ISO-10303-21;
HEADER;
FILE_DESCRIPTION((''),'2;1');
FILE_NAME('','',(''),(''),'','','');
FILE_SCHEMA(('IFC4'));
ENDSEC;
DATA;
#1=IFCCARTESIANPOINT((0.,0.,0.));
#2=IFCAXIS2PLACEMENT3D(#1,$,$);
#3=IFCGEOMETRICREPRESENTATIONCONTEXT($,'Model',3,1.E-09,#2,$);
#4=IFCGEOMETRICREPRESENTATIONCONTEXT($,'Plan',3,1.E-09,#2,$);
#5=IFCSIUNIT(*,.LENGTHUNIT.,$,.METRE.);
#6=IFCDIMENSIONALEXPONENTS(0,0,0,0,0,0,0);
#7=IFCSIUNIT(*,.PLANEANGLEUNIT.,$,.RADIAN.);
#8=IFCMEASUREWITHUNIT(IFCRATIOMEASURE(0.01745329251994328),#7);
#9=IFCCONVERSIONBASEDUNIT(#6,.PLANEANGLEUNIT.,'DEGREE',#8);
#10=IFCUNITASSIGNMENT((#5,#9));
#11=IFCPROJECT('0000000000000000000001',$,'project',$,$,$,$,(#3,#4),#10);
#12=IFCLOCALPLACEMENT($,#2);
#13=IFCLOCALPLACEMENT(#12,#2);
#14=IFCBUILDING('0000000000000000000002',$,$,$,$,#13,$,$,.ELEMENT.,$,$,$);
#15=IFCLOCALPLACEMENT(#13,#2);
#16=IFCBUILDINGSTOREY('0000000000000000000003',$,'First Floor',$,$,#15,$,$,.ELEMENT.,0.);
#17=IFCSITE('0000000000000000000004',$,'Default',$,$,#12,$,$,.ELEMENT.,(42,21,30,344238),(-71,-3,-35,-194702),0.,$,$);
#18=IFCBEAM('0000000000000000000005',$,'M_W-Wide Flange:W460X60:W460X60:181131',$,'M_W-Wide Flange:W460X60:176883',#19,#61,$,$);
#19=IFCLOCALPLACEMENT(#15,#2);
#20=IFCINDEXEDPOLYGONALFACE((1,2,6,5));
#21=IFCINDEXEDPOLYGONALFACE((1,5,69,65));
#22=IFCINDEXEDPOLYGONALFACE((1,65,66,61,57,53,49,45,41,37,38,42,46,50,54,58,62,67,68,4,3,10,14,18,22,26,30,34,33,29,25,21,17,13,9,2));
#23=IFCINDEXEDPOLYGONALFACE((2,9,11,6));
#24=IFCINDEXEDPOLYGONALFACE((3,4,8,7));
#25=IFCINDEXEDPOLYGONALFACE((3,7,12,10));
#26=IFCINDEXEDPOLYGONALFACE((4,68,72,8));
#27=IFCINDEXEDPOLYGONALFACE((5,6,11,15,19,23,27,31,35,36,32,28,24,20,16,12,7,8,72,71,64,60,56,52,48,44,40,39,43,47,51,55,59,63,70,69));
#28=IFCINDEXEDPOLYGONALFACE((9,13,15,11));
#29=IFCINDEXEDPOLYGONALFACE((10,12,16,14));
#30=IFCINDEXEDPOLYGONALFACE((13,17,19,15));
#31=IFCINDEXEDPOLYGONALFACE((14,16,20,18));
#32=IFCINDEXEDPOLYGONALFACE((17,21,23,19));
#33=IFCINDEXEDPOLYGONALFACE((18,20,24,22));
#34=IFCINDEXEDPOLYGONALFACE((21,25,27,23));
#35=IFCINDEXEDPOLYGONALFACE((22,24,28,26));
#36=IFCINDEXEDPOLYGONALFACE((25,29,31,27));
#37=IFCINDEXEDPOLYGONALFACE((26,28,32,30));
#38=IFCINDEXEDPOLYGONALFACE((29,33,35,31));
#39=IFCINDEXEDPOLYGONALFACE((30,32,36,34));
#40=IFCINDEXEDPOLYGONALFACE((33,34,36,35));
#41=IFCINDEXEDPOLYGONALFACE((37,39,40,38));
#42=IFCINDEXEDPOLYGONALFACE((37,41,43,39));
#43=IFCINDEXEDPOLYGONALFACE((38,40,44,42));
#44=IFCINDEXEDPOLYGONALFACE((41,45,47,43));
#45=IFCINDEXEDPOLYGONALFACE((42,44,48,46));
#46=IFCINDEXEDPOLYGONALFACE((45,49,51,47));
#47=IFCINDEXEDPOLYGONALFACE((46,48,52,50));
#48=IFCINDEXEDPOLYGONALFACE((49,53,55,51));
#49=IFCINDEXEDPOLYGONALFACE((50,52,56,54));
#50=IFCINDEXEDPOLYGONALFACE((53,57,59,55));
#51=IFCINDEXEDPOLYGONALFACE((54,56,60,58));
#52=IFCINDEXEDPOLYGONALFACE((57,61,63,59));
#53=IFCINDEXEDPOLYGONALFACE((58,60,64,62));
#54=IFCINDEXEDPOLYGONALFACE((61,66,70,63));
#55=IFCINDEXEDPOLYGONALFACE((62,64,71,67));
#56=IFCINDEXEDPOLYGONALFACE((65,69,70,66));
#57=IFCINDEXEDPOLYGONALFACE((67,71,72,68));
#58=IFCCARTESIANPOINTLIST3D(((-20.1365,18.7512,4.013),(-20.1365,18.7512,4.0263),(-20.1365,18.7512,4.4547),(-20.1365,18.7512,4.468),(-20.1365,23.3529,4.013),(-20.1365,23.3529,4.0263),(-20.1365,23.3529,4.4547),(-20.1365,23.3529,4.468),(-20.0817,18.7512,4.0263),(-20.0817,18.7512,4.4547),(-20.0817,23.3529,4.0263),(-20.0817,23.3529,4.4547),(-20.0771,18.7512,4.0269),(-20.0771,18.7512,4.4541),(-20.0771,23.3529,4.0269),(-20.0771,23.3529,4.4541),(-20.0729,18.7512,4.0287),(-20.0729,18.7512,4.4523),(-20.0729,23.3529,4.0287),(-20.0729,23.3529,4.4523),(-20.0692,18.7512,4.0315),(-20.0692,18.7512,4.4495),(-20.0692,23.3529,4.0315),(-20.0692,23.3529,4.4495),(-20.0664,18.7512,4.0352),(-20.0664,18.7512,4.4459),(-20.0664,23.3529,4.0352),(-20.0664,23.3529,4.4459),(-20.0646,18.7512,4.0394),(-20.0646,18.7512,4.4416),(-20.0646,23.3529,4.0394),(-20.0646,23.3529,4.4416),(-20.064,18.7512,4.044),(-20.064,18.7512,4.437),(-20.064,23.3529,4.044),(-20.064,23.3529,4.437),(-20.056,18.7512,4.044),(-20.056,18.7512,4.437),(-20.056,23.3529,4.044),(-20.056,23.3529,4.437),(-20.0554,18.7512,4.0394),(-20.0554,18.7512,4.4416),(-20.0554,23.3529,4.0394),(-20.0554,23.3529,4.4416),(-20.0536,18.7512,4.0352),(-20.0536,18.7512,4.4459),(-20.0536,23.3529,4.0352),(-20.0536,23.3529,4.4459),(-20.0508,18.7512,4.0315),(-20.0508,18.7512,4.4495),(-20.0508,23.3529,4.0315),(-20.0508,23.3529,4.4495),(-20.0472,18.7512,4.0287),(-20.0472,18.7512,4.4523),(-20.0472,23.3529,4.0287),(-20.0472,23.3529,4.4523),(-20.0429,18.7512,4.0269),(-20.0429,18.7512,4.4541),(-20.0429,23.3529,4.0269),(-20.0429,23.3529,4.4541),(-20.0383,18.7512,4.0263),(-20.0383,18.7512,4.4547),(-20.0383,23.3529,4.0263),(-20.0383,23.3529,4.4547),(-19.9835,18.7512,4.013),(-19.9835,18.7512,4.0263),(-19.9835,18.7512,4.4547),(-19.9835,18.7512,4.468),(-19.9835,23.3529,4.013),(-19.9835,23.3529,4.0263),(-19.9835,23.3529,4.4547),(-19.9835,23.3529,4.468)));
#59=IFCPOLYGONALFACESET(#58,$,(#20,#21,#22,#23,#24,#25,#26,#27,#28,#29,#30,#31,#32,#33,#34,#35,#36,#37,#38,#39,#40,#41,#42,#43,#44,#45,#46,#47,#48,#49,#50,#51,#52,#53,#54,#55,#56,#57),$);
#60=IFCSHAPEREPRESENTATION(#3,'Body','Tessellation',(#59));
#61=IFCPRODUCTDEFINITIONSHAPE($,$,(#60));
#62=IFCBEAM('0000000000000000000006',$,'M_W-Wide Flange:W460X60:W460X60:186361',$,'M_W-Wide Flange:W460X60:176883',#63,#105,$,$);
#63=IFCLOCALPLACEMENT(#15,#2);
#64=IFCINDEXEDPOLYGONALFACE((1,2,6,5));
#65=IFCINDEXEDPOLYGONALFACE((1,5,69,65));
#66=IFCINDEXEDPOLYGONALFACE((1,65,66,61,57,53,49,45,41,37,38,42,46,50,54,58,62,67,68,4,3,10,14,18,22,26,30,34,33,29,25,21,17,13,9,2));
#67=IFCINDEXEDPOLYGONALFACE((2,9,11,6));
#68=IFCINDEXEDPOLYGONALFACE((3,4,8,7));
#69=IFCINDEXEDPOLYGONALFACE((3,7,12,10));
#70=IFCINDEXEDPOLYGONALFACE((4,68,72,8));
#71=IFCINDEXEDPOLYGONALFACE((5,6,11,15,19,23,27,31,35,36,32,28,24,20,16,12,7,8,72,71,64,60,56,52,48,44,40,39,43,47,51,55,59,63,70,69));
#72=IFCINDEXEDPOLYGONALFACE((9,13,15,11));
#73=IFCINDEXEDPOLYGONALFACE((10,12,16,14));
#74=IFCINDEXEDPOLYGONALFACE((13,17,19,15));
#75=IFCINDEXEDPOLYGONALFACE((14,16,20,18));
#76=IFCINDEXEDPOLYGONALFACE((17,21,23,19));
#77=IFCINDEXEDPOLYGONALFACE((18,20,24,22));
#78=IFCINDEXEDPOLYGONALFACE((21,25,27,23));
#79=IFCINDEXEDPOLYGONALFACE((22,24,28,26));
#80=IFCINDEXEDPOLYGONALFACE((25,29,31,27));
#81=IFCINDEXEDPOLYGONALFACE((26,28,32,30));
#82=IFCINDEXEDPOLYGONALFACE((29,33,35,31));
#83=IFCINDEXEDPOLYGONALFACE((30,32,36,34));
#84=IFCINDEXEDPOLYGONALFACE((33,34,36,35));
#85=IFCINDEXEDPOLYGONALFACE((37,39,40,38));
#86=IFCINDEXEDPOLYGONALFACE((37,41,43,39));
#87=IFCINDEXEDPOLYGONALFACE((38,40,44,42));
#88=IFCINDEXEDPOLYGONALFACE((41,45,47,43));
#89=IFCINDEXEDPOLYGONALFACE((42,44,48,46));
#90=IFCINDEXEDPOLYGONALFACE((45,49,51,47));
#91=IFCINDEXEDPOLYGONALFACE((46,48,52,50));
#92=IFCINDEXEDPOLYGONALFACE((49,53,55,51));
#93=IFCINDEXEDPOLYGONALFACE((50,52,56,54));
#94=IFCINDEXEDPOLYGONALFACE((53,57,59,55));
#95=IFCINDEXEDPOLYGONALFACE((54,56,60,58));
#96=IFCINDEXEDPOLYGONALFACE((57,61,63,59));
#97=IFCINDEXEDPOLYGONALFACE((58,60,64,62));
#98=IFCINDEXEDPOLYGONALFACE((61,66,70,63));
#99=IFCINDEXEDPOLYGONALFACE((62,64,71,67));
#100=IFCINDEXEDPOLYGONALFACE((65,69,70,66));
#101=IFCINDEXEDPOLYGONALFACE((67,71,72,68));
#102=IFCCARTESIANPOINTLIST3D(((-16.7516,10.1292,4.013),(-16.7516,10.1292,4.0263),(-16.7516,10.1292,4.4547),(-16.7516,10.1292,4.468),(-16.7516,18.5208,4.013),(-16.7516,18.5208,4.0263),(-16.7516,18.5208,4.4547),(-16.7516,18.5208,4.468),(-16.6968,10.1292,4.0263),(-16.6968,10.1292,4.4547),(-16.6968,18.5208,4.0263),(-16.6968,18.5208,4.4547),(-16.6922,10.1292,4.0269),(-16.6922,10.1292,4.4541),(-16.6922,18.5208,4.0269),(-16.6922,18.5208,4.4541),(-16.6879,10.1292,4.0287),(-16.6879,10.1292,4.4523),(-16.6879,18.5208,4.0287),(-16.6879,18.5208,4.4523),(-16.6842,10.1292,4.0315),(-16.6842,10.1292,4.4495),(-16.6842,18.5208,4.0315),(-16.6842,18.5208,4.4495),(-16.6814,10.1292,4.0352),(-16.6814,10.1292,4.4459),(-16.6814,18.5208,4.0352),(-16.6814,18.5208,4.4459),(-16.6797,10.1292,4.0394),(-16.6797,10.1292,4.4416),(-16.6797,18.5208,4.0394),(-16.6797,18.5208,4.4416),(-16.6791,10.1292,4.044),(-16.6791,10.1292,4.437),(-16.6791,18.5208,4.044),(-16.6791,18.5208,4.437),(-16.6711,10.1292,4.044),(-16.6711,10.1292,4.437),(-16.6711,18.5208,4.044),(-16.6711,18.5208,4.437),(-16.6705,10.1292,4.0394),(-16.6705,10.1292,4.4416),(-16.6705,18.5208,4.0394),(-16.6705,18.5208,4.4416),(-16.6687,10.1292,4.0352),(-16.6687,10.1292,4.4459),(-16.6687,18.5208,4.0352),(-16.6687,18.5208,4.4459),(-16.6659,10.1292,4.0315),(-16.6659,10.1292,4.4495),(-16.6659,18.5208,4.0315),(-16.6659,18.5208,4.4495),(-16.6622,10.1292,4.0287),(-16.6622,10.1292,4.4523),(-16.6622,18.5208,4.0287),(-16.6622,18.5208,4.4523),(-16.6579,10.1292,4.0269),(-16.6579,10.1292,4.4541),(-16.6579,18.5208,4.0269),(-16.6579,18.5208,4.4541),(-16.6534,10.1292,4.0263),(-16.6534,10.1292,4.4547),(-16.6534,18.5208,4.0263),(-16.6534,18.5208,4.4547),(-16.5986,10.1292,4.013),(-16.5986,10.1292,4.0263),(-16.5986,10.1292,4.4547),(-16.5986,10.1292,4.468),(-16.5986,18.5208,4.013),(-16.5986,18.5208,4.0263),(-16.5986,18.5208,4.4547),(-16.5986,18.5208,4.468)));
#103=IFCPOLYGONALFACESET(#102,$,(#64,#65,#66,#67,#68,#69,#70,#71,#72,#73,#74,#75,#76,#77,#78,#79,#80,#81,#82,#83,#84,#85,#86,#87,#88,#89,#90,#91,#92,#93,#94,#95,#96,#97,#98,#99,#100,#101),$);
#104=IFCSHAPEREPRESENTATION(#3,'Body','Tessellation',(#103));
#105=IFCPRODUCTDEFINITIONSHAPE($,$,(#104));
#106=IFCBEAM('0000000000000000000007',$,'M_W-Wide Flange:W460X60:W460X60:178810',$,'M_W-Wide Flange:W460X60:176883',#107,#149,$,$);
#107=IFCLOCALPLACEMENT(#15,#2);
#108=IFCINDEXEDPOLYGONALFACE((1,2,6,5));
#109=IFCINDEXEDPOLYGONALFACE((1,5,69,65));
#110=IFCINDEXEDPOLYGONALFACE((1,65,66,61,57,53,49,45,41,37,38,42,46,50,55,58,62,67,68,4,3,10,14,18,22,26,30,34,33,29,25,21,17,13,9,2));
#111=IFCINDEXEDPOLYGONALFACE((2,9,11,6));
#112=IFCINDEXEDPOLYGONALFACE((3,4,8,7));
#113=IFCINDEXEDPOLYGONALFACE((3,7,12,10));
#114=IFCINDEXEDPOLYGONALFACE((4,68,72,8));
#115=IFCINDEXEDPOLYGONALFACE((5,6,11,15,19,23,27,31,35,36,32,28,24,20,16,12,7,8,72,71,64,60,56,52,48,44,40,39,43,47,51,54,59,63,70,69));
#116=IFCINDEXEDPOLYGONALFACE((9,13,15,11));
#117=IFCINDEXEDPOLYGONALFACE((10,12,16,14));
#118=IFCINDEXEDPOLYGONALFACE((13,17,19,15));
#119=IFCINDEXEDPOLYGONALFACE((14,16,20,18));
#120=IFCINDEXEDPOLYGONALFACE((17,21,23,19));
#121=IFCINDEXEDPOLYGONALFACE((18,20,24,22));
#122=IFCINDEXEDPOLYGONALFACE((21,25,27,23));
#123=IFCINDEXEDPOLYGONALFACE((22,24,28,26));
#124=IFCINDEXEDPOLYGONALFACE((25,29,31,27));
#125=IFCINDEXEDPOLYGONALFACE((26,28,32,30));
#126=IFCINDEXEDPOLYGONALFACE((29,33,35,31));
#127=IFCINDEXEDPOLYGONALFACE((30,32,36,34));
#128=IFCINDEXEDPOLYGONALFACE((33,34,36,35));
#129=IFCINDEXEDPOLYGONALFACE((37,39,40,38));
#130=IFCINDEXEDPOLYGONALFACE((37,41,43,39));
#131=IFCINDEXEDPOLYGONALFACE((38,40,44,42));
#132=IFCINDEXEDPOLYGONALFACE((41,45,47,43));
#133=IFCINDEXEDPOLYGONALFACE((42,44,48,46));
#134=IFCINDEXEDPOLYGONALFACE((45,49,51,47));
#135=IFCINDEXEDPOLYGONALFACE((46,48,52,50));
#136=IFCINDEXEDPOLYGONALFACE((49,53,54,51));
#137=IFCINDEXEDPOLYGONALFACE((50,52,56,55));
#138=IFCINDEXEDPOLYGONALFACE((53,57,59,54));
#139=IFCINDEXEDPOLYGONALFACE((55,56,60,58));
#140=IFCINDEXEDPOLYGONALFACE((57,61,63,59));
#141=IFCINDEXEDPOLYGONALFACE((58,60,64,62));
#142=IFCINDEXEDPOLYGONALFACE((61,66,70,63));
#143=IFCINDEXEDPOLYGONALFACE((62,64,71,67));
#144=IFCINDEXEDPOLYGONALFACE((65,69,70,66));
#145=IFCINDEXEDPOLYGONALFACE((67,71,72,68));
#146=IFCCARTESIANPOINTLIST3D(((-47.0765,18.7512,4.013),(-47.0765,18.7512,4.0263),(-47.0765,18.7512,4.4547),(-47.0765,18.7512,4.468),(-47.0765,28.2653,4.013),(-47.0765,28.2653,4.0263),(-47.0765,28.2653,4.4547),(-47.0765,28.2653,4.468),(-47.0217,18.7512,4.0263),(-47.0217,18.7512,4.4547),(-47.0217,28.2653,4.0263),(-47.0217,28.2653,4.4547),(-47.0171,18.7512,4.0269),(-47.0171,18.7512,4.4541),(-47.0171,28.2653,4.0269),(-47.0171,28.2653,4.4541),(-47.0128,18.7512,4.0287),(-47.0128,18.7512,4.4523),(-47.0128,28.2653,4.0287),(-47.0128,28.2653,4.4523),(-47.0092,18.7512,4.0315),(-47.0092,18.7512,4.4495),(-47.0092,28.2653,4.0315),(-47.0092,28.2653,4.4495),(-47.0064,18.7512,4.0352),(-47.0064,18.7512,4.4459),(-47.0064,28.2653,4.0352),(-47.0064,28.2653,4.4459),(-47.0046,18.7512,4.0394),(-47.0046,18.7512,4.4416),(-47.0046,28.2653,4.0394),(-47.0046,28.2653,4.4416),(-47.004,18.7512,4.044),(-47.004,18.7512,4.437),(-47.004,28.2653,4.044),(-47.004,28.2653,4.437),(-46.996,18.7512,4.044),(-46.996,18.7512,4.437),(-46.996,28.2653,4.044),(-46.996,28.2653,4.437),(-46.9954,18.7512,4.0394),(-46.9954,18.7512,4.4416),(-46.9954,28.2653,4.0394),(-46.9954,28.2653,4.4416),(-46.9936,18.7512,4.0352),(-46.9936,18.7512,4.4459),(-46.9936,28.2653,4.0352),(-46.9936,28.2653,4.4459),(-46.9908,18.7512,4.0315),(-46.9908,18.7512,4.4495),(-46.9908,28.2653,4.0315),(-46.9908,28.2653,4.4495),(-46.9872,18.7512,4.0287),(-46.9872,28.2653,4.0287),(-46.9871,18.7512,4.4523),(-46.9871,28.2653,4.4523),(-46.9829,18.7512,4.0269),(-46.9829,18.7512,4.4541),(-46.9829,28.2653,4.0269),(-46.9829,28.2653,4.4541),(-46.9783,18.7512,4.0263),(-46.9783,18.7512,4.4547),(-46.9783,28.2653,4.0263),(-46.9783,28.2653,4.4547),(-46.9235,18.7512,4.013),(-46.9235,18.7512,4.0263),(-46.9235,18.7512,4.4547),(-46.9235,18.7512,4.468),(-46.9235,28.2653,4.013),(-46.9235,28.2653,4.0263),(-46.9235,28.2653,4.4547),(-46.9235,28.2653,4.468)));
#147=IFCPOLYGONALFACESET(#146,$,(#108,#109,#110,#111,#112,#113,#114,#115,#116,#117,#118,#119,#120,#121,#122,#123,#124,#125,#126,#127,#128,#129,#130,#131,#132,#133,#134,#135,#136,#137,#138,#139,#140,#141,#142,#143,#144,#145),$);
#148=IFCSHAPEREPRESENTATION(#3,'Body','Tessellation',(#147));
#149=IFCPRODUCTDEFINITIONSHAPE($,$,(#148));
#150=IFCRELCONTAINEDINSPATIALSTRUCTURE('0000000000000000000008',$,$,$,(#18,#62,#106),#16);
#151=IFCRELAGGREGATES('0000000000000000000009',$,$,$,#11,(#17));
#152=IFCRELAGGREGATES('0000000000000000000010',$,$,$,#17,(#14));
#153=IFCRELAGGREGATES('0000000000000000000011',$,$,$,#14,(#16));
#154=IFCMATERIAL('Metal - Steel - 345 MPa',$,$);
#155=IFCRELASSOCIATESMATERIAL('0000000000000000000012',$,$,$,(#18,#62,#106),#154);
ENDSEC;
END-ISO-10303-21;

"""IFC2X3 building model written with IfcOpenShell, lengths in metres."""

from ifc_helpers import new_model, entity, si_unit, converted_unit, frame, frame_2d, origin, place, context, project, spatial, polyline, circle_curve, parameter, trimmed, segment, composite_curve, outline, extrude, material, element, save


model = new_model("IFC2X3")

# Units and contexts
model_context = context("Model", 3, precision=1e-09, world=origin())
plan_context = context("Plan", 3, precision=1e-09, world=origin())
ifc_project = project(units=[si_unit("LENGTHUNIT", "METRE"), converted_unit("PLANEANGLEUNIT", "DEGREE", entity("IfcRatioMeasure", 0.01745329251994328), si_unit("PLANEANGLEUNIT", "RADIAN"), dimensions=[0, 0, 0, 0, 0, 0, 0])], contexts=[model_context, plan_context])

# Site, building, storey
site_placement = place(None, origin())
site = spatial("IfcSite", under=ifc_project, at=site_placement, Name="Default", CompositionType="ELEMENT", RefLatitude=(42, 21, 30, 344238), RefLongitude=(-71, -3, -35, -194702), RefElevation=0.0)
building_placement = place(site_placement, origin())
building = spatial("IfcBuilding", under=site, at=building_placement, CompositionType="ELEMENT")
storey_placement = place(building_placement, origin())
storey = spatial("IfcBuildingStorey", under=building, at=storey_placement, Name="First Floor", CompositionType="ELEMENT", Elevation=0.0)

# Beams
ifc_material_1 = material(Name="Metal - Steel - 345 MPa")
beam_1_placement = place(storey_placement, frame((-20.06, 23.4969, 4.468), z_axis=(0.0, 0.0, 1.0), x_axis=(-1.0, 0.0, 0.0)))
element("IfcBeam", 1, at=beam_1_placement, inside=storey, material=ifc_material_1, Name="M_W-Wide Flange:W460X60:W460X60:181131", ObjectType="M_W-Wide Flange:W460X60:176883", context=model_context, shape_type="SweptSolid", body=[
    extrude(outline(composite_curve([segment(polyline([(0.2142, -0.0765), (0.2275, -0.0765)]), True, "CONTINUOUS"), segment(polyline([(0.2275, -0.0765), (0.2275, 0.0765)]), True, "CONTINUOUS"), segment(polyline([(0.2275, 0.0765), (0.2142, 0.0765)]), True, "CONTINUOUS"), segment(polyline([(0.2142, 0.0765), (0.2142, 0.0217)]), True, "CONTINUOUS"), segment(trimmed(circle_curve(frame_2d((0.1965, 0.0217), x_axis=(1.0, 0.0)), 0.0177), [parameter(270.0)], [parameter(360.0)], True, "PARAMETER"), False, "CONTINUOUS"), segment(polyline([(0.1965, 0.004), (-0.1965, 0.004)]), True, "CONTINUOUS"), segment(trimmed(circle_curve(frame_2d((-0.1965, 0.0217), x_axis=(0.0, -1.0)), 0.0177), [parameter(270.0)], [parameter(360.0)], True, "PARAMETER"), False, "CONTINUOUS"), segment(polyline([(-0.2142, 0.0217), (-0.2142, 0.0765)]), True, "CONTINUOUS"), segment(polyline([(-0.2142, 0.0765), (-0.2275, 0.0765)]), True, "CONTINUOUS"), segment(polyline([(-0.2275, 0.0765), (-0.2275, -0.0765)]), True, "CONTINUOUS"), segment(polyline([(-0.2275, -0.0765), (-0.2142, -0.0765)]), True, "CONTINUOUS"), segment(polyline([(-0.2142, -0.0765), (-0.2142, -0.0217)]), True, "CONTINUOUS"), segment(trimmed(circle_curve(frame_2d((-0.1965, -0.0217), x_axis=(-1.0, 0.0)), 0.0177), [parameter(270.0)], [parameter(360.0)], True, "PARAMETER"), False, "CONTINUOUS"), segment(polyline([(-0.1965, -0.004), (0.1965, -0.004)]), True, "CONTINUOUS"), segment(trimmed(circle_curve(frame_2d((0.1965, -0.0217), x_axis=(0.0, 1.0)), 0.0177), [parameter(270.0)], [parameter(0.0)], True, "PARAMETER"), False, "CONTINUOUS"), segment(polyline([(0.2142, -0.0217), (0.2142, -0.0765)]), True, "CONTINUOUS")], self_intersect=False)), frame((0.0, 4.7457, -0.2275), z_axis=(0.0, -1.0, 0.0), x_axis=(0.0, 0.0, -1.0)), (0.0, 0.0, 1.0), 4.6017),
])
beam_2_placement = place(storey_placement, frame((-16.6751, 10.1909, 4.468)))
element("IfcBeam", 2, at=beam_2_placement, inside=storey, material=ifc_material_1, Name="M_W-Wide Flange:W460X60:W460X60:186361", ObjectType="M_W-Wide Flange:W460X60:176883", context=model_context, shape_type="SweptSolid", body=[
    extrude(outline(composite_curve([segment(polyline([(-0.0765, -0.2142), (-0.0765, -0.2275)]), True, "CONTINUOUS"), segment(polyline([(-0.0765, -0.2275), (0.0765, -0.2275)]), True, "CONTINUOUS"), segment(polyline([(0.0765, -0.2275), (0.0765, -0.2142)]), True, "CONTINUOUS"), segment(polyline([(0.0765, -0.2142), (0.0217, -0.2142)]), True, "CONTINUOUS"), segment(trimmed(circle_curve(frame_2d((0.0217, -0.1965), x_axis=(1.0, 0.0)), 0.0177), [parameter(180.0)], [parameter(270.0)], True, "PARAMETER"), False, "CONTINUOUS"), segment(polyline([(0.004, -0.1965), (0.004, 0.1965)]), True, "CONTINUOUS"), segment(trimmed(circle_curve(frame_2d((0.0217, 0.1965), x_axis=(1.0, 0.0)), 0.0177), [parameter(90.0)], [parameter(180.0)], True, "PARAMETER"), False, "CONTINUOUS"), segment(polyline([(0.0217, 0.2142), (0.0765, 0.2142)]), True, "CONTINUOUS"), segment(polyline([(0.0765, 0.2142), (0.0765, 0.2275)]), True, "CONTINUOUS"), segment(polyline([(0.0765, 0.2275), (-0.0765, 0.2275)]), True, "CONTINUOUS"), segment(polyline([(-0.0765, 0.2275), (-0.0765, 0.2142)]), True, "CONTINUOUS"), segment(polyline([(-0.0765, 0.2142), (-0.0217, 0.2142)]), True, "CONTINUOUS"), segment(trimmed(circle_curve(frame_2d((-0.0217, 0.1965), x_axis=(1.0, 0.0)), 0.0177), [parameter(360.0)], [parameter(90.0)], True, "PARAMETER"), False, "CONTINUOUS"), segment(polyline([(-0.004, 0.1965), (-0.004, -0.1965)]), True, "CONTINUOUS"), segment(trimmed(circle_curve(frame_2d((-0.0217, -0.1965), x_axis=(1.0, 0.0)), 0.0177), [parameter(270.0)], [parameter(0.0)], True, "PARAMETER"), False, "CONTINUOUS"), segment(polyline([(-0.0217, -0.2142), (-0.0765, -0.2142)]), True, "CONTINUOUS")], self_intersect=False)), frame((0.0, -0.0617, -0.2275), z_axis=(0.0, -1.0, 0.0), x_axis=(1.0, 0.0, 0.0)), (0.0, 0.0, -1.0), 8.3916),
])
beam_3_placement = place(storey_placement, frame((-47.0, 18.6086, 4.468)))
element("IfcBeam", 3, at=beam_3_placement, inside=storey, material=ifc_material_1, Name="M_W-Wide Flange:W460X60:W460X60:178810", ObjectType="M_W-Wide Flange:W460X60:176883", context=model_context, shape_type="SweptSolid", body=[
    extrude(outline(composite_curve([segment(polyline([(-0.0765, -0.2142), (-0.0765, -0.2275)]), True, "CONTINUOUS"), segment(polyline([(-0.0765, -0.2275), (0.0765, -0.2275)]), True, "CONTINUOUS"), segment(polyline([(0.0765, -0.2275), (0.0765, -0.2142)]), True, "CONTINUOUS"), segment(polyline([(0.0765, -0.2142), (0.0217, -0.2142)]), True, "CONTINUOUS"), segment(trimmed(circle_curve(frame_2d((0.0217, -0.1965), x_axis=(0.0, -1.0)), 0.0177), [parameter(270.0)], [parameter(360.0)], True, "PARAMETER"), False, "CONTINUOUS"), segment(polyline([(0.004, -0.1965), (0.004, 0.1965)]), True, "CONTINUOUS"), segment(trimmed(circle_curve(frame_2d((0.0217, 0.1965), x_axis=(-1.0, 0.0)), 0.0177), [parameter(270.0)], [parameter(360.0)], True, "PARAMETER"), False, "CONTINUOUS"), segment(polyline([(0.0217, 0.2142), (0.0765, 0.2142)]), True, "CONTINUOUS"), segment(polyline([(0.0765, 0.2142), (0.0765, 0.2275)]), True, "CONTINUOUS"), segment(polyline([(0.0765, 0.2275), (-0.0765, 0.2275)]), True, "CONTINUOUS"), segment(polyline([(-0.0765, 0.2275), (-0.0765, 0.2142)]), True, "CONTINUOUS"), segment(polyline([(-0.0765, 0.2142), (-0.0217, 0.2142)]), True, "CONTINUOUS"), segment(trimmed(circle_curve(frame_2d((-0.0217, 0.1965), x_axis=(0.0, 1.0)), 0.0177), [parameter(270.0)], [parameter(360.0)], True, "PARAMETER"), False, "CONTINUOUS"), segment(polyline([(-0.004, 0.1965), (-0.004, -0.1965)]), True, "CONTINUOUS"), segment(trimmed(circle_curve(frame_2d((-0.0217, -0.1965), x_axis=(1.0, 0.0)), 0.0177), [parameter(270.0)], [parameter(0.0)], True, "PARAMETER"), False, "CONTINUOUS"), segment(polyline([(-0.0217, -0.2142), (-0.0765, -0.2142)]), True, "CONTINUOUS")], self_intersect=False)), frame((0.0, 0.1426, -0.2275), z_axis=(0.0, -1.0, 0.0), x_axis=(1.0, 0.0, 0.0)), (0.0, 0.0, -1.0), 9.5141),
])

save(model, "model.ifc")
